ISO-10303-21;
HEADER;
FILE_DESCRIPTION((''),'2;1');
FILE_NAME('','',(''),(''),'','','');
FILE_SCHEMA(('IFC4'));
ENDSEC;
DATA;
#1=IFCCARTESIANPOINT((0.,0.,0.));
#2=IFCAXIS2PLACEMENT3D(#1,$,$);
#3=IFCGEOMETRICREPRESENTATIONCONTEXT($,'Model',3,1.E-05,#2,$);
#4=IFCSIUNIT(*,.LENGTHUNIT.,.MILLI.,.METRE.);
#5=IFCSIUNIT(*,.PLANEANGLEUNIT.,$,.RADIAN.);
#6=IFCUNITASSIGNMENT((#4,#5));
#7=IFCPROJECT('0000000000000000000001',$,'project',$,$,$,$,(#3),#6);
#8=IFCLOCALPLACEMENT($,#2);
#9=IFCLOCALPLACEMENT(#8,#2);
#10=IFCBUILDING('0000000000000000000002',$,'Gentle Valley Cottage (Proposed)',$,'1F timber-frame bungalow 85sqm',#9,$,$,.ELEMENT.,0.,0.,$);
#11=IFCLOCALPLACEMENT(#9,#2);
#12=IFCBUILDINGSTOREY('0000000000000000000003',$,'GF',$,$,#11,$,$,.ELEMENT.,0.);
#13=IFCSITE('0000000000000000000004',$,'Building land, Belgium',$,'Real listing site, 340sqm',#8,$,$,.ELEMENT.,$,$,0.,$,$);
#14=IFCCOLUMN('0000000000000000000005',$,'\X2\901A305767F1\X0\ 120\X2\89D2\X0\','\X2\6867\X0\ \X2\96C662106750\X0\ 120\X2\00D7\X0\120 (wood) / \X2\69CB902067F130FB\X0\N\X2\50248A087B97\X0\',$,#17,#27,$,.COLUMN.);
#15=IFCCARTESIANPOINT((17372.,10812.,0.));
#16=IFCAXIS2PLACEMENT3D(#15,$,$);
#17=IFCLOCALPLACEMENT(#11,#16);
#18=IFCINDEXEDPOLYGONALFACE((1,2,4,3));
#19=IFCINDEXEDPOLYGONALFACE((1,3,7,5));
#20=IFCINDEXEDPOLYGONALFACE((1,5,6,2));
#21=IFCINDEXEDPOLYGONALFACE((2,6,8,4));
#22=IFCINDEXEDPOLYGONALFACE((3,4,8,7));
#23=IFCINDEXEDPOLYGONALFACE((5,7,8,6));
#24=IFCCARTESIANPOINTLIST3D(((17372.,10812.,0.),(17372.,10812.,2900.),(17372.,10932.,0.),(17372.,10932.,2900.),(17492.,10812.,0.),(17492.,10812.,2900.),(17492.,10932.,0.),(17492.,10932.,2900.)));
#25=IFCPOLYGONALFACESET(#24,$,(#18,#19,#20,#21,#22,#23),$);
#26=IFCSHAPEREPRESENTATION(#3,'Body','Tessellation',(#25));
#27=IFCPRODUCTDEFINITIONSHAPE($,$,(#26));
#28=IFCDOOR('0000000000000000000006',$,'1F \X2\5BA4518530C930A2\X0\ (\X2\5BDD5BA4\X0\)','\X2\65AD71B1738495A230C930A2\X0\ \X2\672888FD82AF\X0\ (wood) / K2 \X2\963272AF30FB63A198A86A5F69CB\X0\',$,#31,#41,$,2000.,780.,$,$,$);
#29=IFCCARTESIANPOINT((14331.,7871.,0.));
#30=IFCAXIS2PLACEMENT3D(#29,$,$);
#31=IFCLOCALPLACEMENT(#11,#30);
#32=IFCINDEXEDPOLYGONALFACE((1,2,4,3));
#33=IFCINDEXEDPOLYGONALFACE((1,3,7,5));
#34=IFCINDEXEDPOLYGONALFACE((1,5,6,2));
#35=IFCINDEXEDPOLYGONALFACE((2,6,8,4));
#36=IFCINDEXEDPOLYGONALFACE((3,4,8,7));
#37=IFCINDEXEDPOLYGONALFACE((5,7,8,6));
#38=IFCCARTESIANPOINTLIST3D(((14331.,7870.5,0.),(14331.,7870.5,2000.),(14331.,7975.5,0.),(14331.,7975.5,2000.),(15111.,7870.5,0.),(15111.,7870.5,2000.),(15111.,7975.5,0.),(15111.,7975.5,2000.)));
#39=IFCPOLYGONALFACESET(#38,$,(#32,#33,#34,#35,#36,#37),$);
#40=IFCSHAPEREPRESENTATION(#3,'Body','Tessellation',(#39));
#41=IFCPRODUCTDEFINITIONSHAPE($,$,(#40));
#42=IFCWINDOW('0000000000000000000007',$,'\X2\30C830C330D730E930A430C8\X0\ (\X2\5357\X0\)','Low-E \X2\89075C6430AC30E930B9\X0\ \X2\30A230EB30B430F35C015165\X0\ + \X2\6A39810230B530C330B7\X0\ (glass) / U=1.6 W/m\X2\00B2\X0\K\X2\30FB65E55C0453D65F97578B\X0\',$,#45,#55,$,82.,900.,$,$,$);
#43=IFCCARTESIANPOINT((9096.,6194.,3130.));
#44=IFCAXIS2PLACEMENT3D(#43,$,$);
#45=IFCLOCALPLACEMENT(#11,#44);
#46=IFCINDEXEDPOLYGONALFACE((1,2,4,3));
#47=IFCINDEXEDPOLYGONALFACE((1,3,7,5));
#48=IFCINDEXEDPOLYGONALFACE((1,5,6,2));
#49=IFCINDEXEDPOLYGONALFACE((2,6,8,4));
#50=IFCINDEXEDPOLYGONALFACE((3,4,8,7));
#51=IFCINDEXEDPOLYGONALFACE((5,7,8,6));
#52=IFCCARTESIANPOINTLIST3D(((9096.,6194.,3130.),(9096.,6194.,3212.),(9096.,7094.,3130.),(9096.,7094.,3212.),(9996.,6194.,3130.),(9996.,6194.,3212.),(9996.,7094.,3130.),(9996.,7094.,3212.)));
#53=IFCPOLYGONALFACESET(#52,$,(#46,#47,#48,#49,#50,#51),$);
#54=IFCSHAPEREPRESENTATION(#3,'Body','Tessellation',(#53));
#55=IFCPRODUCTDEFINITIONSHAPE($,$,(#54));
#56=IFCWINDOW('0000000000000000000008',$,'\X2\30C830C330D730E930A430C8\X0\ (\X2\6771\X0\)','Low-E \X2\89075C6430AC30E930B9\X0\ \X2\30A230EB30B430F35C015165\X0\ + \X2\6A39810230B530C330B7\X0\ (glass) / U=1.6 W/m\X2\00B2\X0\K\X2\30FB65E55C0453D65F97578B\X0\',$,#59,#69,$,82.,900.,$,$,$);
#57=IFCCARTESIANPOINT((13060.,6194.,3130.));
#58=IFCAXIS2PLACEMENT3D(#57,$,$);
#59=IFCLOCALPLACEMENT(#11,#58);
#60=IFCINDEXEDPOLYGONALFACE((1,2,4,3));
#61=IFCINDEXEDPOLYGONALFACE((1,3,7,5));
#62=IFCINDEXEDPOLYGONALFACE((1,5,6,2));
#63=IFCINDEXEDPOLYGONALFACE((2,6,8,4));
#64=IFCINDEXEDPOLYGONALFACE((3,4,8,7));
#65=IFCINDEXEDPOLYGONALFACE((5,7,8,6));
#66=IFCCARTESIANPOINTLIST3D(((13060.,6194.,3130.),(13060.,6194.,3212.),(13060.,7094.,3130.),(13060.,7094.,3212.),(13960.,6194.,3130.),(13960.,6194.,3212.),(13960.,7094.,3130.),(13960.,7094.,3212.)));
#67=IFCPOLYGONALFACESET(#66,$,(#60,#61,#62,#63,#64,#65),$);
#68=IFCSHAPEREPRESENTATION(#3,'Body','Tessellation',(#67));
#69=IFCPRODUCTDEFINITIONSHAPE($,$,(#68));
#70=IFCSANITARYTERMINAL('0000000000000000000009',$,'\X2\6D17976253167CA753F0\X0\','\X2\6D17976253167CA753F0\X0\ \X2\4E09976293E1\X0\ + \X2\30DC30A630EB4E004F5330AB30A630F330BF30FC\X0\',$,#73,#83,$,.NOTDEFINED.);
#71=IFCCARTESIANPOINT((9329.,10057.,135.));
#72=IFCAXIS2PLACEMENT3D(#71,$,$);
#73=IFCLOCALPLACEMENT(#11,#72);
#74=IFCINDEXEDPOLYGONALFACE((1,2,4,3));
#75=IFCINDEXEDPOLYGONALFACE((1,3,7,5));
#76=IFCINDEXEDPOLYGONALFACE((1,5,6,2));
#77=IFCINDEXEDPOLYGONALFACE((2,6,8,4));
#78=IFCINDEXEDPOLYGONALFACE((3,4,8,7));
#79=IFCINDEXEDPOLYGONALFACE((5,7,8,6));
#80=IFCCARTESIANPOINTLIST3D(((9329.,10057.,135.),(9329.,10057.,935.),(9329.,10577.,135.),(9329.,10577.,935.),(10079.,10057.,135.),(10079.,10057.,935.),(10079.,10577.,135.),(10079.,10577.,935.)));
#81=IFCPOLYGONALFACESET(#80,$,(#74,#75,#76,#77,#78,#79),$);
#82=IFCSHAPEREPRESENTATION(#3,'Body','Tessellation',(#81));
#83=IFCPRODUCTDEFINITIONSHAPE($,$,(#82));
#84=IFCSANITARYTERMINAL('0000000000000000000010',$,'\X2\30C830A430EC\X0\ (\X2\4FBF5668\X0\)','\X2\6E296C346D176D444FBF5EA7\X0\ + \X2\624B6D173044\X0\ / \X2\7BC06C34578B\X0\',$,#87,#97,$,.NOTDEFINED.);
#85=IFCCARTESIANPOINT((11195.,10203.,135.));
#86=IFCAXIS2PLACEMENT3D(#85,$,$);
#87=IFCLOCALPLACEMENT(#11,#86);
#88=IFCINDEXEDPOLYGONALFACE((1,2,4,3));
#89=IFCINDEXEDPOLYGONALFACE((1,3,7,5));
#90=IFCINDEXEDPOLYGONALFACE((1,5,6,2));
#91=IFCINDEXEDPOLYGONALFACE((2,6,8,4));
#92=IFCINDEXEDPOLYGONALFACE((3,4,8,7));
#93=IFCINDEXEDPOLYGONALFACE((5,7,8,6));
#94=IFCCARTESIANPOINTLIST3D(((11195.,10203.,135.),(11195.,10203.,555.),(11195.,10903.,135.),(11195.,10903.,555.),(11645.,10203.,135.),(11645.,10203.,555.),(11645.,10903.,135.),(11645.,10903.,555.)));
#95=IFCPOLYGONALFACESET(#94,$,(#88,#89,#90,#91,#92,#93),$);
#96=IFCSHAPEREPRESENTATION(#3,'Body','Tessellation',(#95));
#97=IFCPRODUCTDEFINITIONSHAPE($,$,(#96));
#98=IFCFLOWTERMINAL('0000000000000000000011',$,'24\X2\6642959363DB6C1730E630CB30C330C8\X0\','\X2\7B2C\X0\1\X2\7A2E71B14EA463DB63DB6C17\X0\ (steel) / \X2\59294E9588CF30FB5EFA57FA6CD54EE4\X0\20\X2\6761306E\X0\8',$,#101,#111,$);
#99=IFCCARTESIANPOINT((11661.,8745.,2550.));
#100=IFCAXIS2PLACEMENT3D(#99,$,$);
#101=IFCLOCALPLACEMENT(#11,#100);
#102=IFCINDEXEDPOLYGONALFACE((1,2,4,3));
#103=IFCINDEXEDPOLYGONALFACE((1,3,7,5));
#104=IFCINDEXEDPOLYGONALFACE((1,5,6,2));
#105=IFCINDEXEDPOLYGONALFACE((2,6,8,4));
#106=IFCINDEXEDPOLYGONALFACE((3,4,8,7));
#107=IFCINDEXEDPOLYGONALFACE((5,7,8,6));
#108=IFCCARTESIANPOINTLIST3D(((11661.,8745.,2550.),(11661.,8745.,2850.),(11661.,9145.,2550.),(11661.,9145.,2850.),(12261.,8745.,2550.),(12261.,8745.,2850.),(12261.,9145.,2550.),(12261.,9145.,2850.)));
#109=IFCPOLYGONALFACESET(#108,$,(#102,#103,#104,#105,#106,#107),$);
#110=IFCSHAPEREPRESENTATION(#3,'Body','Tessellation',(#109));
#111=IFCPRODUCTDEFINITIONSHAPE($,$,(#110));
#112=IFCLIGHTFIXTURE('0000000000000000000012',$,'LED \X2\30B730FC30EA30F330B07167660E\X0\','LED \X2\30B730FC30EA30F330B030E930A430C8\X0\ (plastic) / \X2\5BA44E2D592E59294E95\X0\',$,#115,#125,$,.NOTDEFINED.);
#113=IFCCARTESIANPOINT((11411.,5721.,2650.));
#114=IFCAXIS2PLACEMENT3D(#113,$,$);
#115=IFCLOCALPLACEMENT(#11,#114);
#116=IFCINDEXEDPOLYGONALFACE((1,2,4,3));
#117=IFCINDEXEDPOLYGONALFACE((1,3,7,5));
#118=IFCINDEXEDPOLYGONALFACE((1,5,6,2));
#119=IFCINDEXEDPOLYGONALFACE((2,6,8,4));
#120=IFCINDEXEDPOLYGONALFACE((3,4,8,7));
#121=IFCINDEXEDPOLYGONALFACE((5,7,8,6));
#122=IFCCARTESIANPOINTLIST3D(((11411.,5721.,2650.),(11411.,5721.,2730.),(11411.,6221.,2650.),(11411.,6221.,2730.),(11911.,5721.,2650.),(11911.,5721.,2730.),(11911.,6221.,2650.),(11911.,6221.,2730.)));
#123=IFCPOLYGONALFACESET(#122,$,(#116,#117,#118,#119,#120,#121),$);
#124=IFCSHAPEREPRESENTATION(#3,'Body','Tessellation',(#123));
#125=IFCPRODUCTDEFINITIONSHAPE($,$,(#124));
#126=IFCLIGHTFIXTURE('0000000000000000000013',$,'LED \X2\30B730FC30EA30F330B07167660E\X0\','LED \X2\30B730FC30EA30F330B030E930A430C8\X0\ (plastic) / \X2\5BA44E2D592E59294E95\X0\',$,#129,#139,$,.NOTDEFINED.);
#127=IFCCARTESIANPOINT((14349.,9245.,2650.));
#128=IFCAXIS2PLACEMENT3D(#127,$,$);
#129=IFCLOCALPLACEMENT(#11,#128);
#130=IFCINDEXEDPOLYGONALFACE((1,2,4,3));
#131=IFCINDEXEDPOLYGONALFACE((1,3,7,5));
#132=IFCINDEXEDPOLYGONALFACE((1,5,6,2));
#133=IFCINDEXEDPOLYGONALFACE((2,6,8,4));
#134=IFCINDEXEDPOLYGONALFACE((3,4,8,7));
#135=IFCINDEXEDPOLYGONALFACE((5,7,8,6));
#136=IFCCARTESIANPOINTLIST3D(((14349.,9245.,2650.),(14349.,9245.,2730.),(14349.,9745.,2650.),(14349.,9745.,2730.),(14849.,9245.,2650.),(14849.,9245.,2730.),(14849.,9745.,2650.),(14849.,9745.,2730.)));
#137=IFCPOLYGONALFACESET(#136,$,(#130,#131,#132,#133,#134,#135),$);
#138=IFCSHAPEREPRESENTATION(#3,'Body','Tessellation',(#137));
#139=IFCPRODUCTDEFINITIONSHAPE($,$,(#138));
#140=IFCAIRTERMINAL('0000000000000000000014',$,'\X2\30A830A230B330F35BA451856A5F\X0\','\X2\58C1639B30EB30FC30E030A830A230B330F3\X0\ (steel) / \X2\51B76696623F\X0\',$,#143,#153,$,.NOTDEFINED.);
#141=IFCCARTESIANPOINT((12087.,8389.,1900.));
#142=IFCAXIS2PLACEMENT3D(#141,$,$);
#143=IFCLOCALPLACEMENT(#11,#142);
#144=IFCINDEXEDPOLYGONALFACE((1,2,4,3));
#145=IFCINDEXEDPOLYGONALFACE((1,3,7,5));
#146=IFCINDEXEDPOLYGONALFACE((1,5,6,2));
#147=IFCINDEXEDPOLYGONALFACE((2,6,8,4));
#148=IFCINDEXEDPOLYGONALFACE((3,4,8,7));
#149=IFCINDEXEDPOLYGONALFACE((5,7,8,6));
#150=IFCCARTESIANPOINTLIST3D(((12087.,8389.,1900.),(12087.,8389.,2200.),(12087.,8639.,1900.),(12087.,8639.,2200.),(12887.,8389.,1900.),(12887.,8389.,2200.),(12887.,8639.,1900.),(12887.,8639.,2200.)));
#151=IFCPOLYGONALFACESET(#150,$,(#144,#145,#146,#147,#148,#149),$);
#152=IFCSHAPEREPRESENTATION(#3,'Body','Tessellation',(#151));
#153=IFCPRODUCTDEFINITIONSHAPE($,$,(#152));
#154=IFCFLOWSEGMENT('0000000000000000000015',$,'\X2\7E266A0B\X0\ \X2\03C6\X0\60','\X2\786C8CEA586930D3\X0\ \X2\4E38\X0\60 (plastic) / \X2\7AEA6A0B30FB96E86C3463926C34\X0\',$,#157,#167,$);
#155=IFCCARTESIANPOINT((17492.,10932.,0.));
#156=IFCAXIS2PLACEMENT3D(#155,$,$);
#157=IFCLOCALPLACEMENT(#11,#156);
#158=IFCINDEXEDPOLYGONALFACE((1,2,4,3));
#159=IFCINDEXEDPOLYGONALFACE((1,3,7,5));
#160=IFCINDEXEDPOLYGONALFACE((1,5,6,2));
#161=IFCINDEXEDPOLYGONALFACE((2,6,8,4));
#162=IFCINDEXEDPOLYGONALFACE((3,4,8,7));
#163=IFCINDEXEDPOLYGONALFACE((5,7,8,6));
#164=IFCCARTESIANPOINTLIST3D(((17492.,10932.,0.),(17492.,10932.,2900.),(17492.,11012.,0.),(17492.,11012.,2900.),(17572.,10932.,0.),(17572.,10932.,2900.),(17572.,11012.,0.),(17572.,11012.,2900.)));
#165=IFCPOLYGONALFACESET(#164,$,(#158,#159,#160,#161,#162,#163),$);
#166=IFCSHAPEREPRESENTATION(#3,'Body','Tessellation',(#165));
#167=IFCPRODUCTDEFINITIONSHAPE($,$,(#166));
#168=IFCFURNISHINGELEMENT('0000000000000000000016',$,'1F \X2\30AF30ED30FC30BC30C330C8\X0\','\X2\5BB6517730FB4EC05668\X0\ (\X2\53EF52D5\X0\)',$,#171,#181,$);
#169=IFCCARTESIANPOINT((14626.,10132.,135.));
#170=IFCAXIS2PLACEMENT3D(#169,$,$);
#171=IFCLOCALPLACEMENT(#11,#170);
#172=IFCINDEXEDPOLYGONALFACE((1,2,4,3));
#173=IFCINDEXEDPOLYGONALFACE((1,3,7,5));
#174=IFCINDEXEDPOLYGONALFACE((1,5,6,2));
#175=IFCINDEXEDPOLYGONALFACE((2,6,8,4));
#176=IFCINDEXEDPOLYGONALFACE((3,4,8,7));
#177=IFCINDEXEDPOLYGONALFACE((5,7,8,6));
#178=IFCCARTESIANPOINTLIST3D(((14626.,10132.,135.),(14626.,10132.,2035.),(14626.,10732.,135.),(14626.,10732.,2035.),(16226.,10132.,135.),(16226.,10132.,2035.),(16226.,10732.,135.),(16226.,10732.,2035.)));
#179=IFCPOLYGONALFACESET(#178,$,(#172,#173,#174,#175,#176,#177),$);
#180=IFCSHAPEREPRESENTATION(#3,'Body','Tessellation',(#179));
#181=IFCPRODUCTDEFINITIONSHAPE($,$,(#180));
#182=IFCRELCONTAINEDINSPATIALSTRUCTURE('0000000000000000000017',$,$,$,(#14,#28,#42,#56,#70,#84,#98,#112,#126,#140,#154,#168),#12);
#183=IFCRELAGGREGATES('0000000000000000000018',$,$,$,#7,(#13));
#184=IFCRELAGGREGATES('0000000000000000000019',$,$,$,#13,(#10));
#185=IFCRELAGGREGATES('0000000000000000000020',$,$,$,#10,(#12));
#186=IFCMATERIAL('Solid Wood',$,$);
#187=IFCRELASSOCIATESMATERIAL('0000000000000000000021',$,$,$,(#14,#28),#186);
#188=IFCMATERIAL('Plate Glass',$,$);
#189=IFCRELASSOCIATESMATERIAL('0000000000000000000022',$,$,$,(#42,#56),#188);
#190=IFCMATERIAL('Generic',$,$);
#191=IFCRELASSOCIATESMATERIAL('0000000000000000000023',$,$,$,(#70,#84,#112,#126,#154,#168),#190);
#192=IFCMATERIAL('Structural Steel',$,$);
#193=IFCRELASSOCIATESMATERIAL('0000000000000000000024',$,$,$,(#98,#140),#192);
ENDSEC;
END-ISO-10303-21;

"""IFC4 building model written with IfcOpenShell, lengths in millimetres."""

from ifc_helpers import new_model, si_unit, frame, frame_2d, origin, place, context, project, spatial, rectangle, extrude, material, element, save


model = new_model("IFC4")

# Units and contexts
model_context = context("Model", 3, precision=1e-05, world=origin())
ifc_project = project(units=[si_unit("LENGTHUNIT", "METRE", prefix="MILLI"), si_unit("PLANEANGLEUNIT", "RADIAN")], contexts=[model_context])

# Site, building, storey
site_placement = place(None, origin())
site = spatial("IfcSite", under=ifc_project, at=site_placement, Name="Building land, Belgium", ObjectType="Real listing site, 340sqm", CompositionType="ELEMENT", RefElevation=0.0)
building_placement = place(site_placement, origin())
building = spatial("IfcBuilding", under=site, at=building_placement, Name="Gentle Valley Cottage (Proposed)", ObjectType="1F timber-frame bungalow 85sqm", CompositionType="ELEMENT", ElevationOfRefHeight=0.0, ElevationOfTerrain=0.0)
storey_placement = place(building_placement, origin())
storey = spatial("IfcBuildingStorey", under=building, at=storey_placement, Name="GF", CompositionType="ELEMENT", Elevation=0.0)

# Column
ifc_material_1 = material(Name="Solid Wood")
column_1_placement = place(storey_placement, frame((17372.0, 10812.0, 0.0)))
element("IfcColumn", 1, at=column_1_placement, inside=storey, material=ifc_material_1, Name="通し柱 120角", Description="桧 集成材 120×120 (wood) / 構造柱・N値計算", PredefinedType="COLUMN", context=model_context, shape_type="SweptSolid", body=[
    extrude(rectangle(XDim=120.0, YDim=120.0, at=frame_2d((60.0, 60.0))), frame((17372.0, 10812.0, 0.0)), (0.0, 0.0, 1.0), 2900.0),
])

# Door
door_placement = place(storey_placement, frame((14331.0, 7871.0, 0.0)))
element("IfcDoor", 2, at=door_placement, inside=storey, material=ifc_material_1, Name="1F 室内ドア (寝室)", Description="断熱玄関ドア 木製芯 (wood) / K2 防犯・採風機構", OverallHeight=2000.0, OverallWidth=780.0, context=model_context, shape_type="SweptSolid", body=[
    extrude(rectangle(XDim=780.0, YDim=105.0, at=frame_2d((390.0, 52.0))), frame((14331.0, 7871.0, 0.0)), (0.0, 0.0, 1.0), 2000.0),
])

# Windows
ifc_material_2 = material(Name="Plate Glass")
window_1_placement = place(storey_placement, frame((9096.0, 6194.0, 3130.0)))
element("IfcWindow", 3, at=window_1_placement, inside=storey, material=ifc_material_2, Name="トップライト (南)", Description="Low-E 複層ガラス アルゴン封入 + 樹脂サッシ (glass) / U=1.6 W/m²K・日射取得型", OverallHeight=82.0, OverallWidth=900.0, context=model_context, shape_type="SweptSolid", body=[
    extrude(rectangle(XDim=900.0, YDim=900.0, at=frame_2d((450.0, 450.0))), frame((9096.0, 6194.0, 3130.0)), (0.0, 0.0, 1.0), 82.0),
])
window_2_placement = place(storey_placement, frame((13060.0, 6194.0, 3130.0)))
element("IfcWindow", 4, at=window_2_placement, inside=storey, material=ifc_material_2, Name="トップライト (東)", Description="Low-E 複層ガラス アルゴン封入 + 樹脂サッシ (glass) / U=1.6 W/m²K・日射取得型", OverallHeight=82.0, OverallWidth=900.0, context=model_context, shape_type="SweptSolid", body=[
    extrude(rectangle(XDim=900.0, YDim=900.0, at=frame_2d((450.0, 450.0))), frame((13060.0, 6194.0, 3130.0)), (0.0, 0.0, 1.0), 82.0),
])

# Sanitary terminals
ifc_material_3 = material(Name="Generic")
sanitary_terminal_1_placement = place(storey_placement, frame((9329.0, 10057.0, 135.0)))
element("IfcSanitaryTerminal", 5, at=sanitary_terminal_1_placement, inside=storey, material=ifc_material_3, Name="洗面化粧台", Description="洗面化粧台 三面鏡 + ボウル一体カウンター", PredefinedType="NOTDEFINED", context=model_context, shape_type="SweptSolid", body=[
    extrude(rectangle(XDim=750.0, YDim=520.0, at=frame_2d((375.0, 260.0))), frame((9329.0, 10057.0, 135.0)), (0.0, 0.0, 1.0), 800.0),
])
sanitary_terminal_2_placement = place(storey_placement, frame((11195.0, 10203.0, 135.0)))
element("IfcSanitaryTerminal", 6, at=sanitary_terminal_2_placement, inside=storey, material=ifc_material_3, Name="トイレ (便器)", Description="温水洗浄便座 + 手洗い / 節水型", PredefinedType="NOTDEFINED", context=model_context, shape_type="SweptSolid", body=[
    extrude(rectangle(XDim=450.0, YDim=700.0, at=frame_2d((225.0, 350.0))), frame((11195.0, 10203.0, 135.0)), (0.0, 0.0, 1.0), 420.0),
])

# Flow terminal
ifc_material_4 = material(Name="Structural Steel")
flow_terminal_placement = place(storey_placement, frame((11661.0, 8745.0, 2550.0)))
element("IfcFlowTerminal", 7, at=flow_terminal_placement, inside=storey, material=ifc_material_4, Name="24時間換気ユニット", Description="第1種熱交換換気 (steel) / 天井裏・建基法令20条の8", context=model_context, shape_type="SweptSolid", body=[
    extrude(rectangle(XDim=600.0, YDim=400.0, at=frame_2d((300.0, 200.0))), frame((11661.0, 8745.0, 2550.0)), (0.0, 0.0, 1.0), 300.0),
])

# Light fixtures
light_fixture_1_placement = place(storey_placement, frame((11411.0, 5721.0, 2650.0)))
element("IfcLightFixture", 8, at=light_fixture_1_placement, inside=storey, material=ifc_material_3, Name="LED シーリング照明", Description="LED シーリングライト (plastic) / 室中央天井", PredefinedType="NOTDEFINED", context=model_context, shape_type="SweptSolid", body=[
    extrude(rectangle(XDim=500.0, YDim=500.0, at=frame_2d((250.0, 250.0))), frame((11411.0, 5721.0, 2650.0)), (0.0, 0.0, 1.0), 80.0),
])
light_fixture_2_placement = place(storey_placement, frame((14349.0, 9245.0, 2650.0)))
element("IfcLightFixture", 9, at=light_fixture_2_placement, inside=storey, material=ifc_material_3, Name="LED シーリング照明", Description="LED シーリングライト (plastic) / 室中央天井", PredefinedType="NOTDEFINED", context=model_context, shape_type="SweptSolid", body=[
    extrude(rectangle(XDim=500.0, YDim=500.0, at=frame_2d((250.0, 250.0))), frame((14349.0, 9245.0, 2650.0)), (0.0, 0.0, 1.0), 80.0),
])

# Air terminal
air_terminal_placement = place(storey_placement, frame((12087.0, 8389.0, 1900.0)))
element("IfcAirTerminal", 10, at=air_terminal_placement, inside=storey, material=ifc_material_4, Name="エアコン室内機", Description="壁掛ルームエアコン (steel) / 冷暖房", PredefinedType="NOTDEFINED", context=model_context, shape_type="SweptSolid", body=[
    extrude(rectangle(XDim=800.0, YDim=250.0, at=frame_2d((400.0, 125.0))), frame((12087.0, 8389.0, 1900.0)), (0.0, 0.0, 1.0), 300.0),
])

# Flow segment
flow_segment_placement = place(storey_placement, frame((17492.0, 10932.0, 0.0)))
element("IfcFlowSegment", 11, at=flow_segment_placement, inside=storey, material=ifc_material_3, Name="縦樋 φ60", Description="硬質塩ビ 丸60 (plastic) / 竪樋・雨水排水", context=model_context, shape_type="SweptSolid", body=[
    extrude(rectangle(XDim=80.0, YDim=80.0, at=frame_2d((40.0, 40.0))), frame((17492.0, 10932.0, 0.0)), (0.0, 0.0, 1.0), 2900.0),
])

# Furnishing element
furnishing_placement = place(storey_placement, frame((14626.0, 10132.0, 135.0)))
element("IfcFurnishingElement", 12, at=furnishing_placement, inside=storey, material=ifc_material_3, Name="1F クローゼット", Description="家具・什器 (可動)", context=model_context, shape_type="SweptSolid", body=[
    extrude(rectangle(XDim=1600.0, YDim=600.0, at=frame_2d((800.0, 300.0))), frame((14626.0, 10132.0, 135.0)), (0.0, 0.0, 1.0), 1900.0),
])

save(model, "model.ifc")
